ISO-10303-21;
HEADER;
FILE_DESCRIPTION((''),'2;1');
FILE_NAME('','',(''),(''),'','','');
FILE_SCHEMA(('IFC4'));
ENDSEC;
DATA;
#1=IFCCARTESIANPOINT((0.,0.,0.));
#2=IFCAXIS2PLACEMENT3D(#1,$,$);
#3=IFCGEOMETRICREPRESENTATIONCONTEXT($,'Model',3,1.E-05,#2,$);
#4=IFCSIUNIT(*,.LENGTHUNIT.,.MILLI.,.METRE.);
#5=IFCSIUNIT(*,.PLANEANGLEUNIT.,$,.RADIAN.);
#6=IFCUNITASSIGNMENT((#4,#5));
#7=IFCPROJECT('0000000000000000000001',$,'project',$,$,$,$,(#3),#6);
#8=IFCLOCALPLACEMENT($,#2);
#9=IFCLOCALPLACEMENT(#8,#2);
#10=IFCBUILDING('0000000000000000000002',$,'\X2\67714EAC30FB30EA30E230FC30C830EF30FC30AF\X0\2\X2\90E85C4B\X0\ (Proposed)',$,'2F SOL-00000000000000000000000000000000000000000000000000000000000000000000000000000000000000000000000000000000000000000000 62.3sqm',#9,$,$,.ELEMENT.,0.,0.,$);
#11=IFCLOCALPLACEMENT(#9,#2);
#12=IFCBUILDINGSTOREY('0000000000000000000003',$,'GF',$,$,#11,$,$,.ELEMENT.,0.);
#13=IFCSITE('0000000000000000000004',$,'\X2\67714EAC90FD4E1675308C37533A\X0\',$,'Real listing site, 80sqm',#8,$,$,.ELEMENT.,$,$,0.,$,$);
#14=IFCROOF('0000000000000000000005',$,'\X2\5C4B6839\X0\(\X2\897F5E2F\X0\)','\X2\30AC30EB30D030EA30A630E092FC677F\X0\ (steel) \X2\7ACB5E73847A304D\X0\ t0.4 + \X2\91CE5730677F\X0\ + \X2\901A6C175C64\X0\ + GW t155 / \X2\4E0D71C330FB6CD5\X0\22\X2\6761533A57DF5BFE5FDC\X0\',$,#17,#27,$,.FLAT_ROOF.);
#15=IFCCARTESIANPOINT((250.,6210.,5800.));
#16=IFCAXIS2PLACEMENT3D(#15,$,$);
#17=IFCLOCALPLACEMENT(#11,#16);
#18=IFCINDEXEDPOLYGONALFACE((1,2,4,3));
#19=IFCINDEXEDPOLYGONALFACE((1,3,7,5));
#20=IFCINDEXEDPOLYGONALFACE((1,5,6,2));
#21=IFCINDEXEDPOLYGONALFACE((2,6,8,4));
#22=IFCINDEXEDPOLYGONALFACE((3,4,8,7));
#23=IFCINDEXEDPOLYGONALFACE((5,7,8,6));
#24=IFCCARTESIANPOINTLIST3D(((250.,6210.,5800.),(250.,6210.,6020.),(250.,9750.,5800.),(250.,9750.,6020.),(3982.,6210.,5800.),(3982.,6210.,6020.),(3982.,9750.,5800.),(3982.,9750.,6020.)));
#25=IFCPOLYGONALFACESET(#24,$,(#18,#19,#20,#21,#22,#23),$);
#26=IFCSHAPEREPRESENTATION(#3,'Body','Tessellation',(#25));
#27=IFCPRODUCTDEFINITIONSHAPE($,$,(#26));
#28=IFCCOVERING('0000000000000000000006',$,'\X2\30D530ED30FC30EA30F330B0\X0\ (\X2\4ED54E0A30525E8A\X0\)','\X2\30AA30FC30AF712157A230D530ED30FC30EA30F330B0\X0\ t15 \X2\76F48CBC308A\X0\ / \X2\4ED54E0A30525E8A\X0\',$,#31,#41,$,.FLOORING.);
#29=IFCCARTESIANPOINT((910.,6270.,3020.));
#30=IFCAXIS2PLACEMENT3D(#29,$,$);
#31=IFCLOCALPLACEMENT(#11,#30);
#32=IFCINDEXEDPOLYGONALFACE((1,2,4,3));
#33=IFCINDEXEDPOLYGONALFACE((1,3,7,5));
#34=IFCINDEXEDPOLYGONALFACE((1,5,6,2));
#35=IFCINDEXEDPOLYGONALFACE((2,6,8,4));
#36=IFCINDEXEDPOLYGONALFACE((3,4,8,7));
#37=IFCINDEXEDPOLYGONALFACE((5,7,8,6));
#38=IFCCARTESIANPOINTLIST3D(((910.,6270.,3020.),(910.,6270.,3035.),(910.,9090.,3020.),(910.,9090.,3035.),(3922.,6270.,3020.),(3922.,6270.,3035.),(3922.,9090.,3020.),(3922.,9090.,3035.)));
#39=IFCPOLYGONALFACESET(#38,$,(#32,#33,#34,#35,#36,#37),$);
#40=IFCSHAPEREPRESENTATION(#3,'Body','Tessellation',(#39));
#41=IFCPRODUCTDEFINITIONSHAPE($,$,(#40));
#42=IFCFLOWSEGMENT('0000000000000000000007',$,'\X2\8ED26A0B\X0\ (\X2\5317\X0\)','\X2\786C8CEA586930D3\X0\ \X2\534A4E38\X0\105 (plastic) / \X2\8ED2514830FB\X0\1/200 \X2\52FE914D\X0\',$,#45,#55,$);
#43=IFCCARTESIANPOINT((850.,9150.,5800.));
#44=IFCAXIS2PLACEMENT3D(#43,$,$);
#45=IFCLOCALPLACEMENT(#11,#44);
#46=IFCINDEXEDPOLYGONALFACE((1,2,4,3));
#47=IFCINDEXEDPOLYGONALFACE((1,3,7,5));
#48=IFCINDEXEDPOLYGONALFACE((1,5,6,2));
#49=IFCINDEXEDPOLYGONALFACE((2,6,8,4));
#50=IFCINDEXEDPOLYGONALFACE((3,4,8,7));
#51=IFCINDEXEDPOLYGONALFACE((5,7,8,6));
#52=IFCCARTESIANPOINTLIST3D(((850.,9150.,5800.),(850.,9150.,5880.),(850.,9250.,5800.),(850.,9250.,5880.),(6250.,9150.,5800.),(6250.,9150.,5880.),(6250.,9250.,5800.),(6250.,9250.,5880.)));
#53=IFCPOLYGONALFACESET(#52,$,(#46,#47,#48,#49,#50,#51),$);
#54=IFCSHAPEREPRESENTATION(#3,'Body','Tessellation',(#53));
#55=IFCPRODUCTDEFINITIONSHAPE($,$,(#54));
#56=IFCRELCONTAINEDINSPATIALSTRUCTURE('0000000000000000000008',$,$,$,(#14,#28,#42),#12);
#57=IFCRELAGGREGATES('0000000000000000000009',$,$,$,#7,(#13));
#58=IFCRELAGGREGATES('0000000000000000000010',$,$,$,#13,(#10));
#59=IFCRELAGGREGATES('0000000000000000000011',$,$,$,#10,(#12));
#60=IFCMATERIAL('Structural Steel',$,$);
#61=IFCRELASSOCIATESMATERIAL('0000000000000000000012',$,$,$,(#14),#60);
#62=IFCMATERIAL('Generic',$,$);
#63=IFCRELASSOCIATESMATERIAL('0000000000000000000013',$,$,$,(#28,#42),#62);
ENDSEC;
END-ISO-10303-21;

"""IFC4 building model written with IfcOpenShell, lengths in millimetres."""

from ifc_helpers import new_model, si_unit, frame, frame_2d, origin, place, context, project, spatial, rectangle, extrude, material, element, save


model = new_model("IFC4")

# Units and contexts
model_context = context("Model", 3, precision=1e-05, world=origin())
ifc_project = project(units=[si_unit("LENGTHUNIT", "METRE", prefix="MILLI"), si_unit("PLANEANGLEUNIT", "RADIAN")], contexts=[model_context])

# Site, building, storey
site_placement = place(None, origin())
site = spatial("IfcSite", under=ifc_project, at=site_placement, Name="東京都世田谷区", ObjectType="Real listing site, 80sqm", CompositionType="ELEMENT", RefElevation=0.0)
building_placement = place(site_placement, origin())
building = spatial("IfcBuilding", under=site, at=building_placement, Name="東京・リモートワーク2部屋 (Proposed)", ObjectType="2F SOL-00000000000000000000000000000000000000000000000000000000000000000000000000000000000000000000000000000000000000000000 62.3sqm", CompositionType="ELEMENT", ElevationOfRefHeight=0.0, ElevationOfTerrain=0.0)
storey_placement = place(building_placement, origin())
storey = spatial("IfcBuildingStorey", under=building, at=storey_placement, Name="GF", CompositionType="ELEMENT", Elevation=0.0)

# Roof
ifc_material_1 = material(Name="Structural Steel")
for number, where, name in (
    (1, (250.0, 6210.0, 5800.0), "屋根(西帯)"),
):
    element("IfcRoof", number, at=place(storey_placement, frame(where)), inside=storey, material=ifc_material_1, Name=name, Description="ガルバリウム鋼板 (steel) 立平葺き t0.4 + 野地板 + 通気層 + GW t155 / 不燃・法22条区域対応", PredefinedType="FLAT_ROOF", context=model_context, shape_type="SweptSolid", body=[
        extrude(rectangle(XDim=3732.0, YDim=3540.0, at=frame_2d((1866.0, 1770.0))), frame((250.0, 6210.0, 5800.0)), (0.0, 0.0, 1.0), 220.0),
    ])

# Covering
ifc_material_2 = material(Name="Generic")
covering_placement = place(storey_placement, frame((910.0, 6270.0, 3020.0)))
element("IfcCovering", 2, at=covering_placement, inside=storey, material=ifc_material_2, Name="フローリング (仕上げ床)", Description="オーク無垢フローリング t15 直貼り / 仕上げ床", PredefinedType="FLOORING", context=model_context, shape_type="SweptSolid", body=[
    extrude(rectangle(XDim=3012.0, YDim=2820.0, at=frame_2d((1506.0, 1410.0))), frame((910.0, 6270.0, 3020.0)), (0.0, 0.0, 1.0), 15.0),
])

# Flow segment
flow_segment_placement = place(storey_placement, frame((850.0, 9150.0, 5800.0)))
element("IfcFlowSegment", 3, at=flow_segment_placement, inside=storey, material=ifc_material_2, Name="軒樋 (北)", Description="硬質塩ビ 半丸105 (plastic) / 軒先・1/200 勾配", context=model_context, shape_type="SweptSolid", body=[
    extrude(rectangle(XDim=5400.0, YDim=100.0, at=frame_2d((2700.0, 50.0))), frame((850.0, 9150.0, 5800.0)), (0.0, 0.0, 1.0), 80.0),
])

save(model, "model.ifc")
